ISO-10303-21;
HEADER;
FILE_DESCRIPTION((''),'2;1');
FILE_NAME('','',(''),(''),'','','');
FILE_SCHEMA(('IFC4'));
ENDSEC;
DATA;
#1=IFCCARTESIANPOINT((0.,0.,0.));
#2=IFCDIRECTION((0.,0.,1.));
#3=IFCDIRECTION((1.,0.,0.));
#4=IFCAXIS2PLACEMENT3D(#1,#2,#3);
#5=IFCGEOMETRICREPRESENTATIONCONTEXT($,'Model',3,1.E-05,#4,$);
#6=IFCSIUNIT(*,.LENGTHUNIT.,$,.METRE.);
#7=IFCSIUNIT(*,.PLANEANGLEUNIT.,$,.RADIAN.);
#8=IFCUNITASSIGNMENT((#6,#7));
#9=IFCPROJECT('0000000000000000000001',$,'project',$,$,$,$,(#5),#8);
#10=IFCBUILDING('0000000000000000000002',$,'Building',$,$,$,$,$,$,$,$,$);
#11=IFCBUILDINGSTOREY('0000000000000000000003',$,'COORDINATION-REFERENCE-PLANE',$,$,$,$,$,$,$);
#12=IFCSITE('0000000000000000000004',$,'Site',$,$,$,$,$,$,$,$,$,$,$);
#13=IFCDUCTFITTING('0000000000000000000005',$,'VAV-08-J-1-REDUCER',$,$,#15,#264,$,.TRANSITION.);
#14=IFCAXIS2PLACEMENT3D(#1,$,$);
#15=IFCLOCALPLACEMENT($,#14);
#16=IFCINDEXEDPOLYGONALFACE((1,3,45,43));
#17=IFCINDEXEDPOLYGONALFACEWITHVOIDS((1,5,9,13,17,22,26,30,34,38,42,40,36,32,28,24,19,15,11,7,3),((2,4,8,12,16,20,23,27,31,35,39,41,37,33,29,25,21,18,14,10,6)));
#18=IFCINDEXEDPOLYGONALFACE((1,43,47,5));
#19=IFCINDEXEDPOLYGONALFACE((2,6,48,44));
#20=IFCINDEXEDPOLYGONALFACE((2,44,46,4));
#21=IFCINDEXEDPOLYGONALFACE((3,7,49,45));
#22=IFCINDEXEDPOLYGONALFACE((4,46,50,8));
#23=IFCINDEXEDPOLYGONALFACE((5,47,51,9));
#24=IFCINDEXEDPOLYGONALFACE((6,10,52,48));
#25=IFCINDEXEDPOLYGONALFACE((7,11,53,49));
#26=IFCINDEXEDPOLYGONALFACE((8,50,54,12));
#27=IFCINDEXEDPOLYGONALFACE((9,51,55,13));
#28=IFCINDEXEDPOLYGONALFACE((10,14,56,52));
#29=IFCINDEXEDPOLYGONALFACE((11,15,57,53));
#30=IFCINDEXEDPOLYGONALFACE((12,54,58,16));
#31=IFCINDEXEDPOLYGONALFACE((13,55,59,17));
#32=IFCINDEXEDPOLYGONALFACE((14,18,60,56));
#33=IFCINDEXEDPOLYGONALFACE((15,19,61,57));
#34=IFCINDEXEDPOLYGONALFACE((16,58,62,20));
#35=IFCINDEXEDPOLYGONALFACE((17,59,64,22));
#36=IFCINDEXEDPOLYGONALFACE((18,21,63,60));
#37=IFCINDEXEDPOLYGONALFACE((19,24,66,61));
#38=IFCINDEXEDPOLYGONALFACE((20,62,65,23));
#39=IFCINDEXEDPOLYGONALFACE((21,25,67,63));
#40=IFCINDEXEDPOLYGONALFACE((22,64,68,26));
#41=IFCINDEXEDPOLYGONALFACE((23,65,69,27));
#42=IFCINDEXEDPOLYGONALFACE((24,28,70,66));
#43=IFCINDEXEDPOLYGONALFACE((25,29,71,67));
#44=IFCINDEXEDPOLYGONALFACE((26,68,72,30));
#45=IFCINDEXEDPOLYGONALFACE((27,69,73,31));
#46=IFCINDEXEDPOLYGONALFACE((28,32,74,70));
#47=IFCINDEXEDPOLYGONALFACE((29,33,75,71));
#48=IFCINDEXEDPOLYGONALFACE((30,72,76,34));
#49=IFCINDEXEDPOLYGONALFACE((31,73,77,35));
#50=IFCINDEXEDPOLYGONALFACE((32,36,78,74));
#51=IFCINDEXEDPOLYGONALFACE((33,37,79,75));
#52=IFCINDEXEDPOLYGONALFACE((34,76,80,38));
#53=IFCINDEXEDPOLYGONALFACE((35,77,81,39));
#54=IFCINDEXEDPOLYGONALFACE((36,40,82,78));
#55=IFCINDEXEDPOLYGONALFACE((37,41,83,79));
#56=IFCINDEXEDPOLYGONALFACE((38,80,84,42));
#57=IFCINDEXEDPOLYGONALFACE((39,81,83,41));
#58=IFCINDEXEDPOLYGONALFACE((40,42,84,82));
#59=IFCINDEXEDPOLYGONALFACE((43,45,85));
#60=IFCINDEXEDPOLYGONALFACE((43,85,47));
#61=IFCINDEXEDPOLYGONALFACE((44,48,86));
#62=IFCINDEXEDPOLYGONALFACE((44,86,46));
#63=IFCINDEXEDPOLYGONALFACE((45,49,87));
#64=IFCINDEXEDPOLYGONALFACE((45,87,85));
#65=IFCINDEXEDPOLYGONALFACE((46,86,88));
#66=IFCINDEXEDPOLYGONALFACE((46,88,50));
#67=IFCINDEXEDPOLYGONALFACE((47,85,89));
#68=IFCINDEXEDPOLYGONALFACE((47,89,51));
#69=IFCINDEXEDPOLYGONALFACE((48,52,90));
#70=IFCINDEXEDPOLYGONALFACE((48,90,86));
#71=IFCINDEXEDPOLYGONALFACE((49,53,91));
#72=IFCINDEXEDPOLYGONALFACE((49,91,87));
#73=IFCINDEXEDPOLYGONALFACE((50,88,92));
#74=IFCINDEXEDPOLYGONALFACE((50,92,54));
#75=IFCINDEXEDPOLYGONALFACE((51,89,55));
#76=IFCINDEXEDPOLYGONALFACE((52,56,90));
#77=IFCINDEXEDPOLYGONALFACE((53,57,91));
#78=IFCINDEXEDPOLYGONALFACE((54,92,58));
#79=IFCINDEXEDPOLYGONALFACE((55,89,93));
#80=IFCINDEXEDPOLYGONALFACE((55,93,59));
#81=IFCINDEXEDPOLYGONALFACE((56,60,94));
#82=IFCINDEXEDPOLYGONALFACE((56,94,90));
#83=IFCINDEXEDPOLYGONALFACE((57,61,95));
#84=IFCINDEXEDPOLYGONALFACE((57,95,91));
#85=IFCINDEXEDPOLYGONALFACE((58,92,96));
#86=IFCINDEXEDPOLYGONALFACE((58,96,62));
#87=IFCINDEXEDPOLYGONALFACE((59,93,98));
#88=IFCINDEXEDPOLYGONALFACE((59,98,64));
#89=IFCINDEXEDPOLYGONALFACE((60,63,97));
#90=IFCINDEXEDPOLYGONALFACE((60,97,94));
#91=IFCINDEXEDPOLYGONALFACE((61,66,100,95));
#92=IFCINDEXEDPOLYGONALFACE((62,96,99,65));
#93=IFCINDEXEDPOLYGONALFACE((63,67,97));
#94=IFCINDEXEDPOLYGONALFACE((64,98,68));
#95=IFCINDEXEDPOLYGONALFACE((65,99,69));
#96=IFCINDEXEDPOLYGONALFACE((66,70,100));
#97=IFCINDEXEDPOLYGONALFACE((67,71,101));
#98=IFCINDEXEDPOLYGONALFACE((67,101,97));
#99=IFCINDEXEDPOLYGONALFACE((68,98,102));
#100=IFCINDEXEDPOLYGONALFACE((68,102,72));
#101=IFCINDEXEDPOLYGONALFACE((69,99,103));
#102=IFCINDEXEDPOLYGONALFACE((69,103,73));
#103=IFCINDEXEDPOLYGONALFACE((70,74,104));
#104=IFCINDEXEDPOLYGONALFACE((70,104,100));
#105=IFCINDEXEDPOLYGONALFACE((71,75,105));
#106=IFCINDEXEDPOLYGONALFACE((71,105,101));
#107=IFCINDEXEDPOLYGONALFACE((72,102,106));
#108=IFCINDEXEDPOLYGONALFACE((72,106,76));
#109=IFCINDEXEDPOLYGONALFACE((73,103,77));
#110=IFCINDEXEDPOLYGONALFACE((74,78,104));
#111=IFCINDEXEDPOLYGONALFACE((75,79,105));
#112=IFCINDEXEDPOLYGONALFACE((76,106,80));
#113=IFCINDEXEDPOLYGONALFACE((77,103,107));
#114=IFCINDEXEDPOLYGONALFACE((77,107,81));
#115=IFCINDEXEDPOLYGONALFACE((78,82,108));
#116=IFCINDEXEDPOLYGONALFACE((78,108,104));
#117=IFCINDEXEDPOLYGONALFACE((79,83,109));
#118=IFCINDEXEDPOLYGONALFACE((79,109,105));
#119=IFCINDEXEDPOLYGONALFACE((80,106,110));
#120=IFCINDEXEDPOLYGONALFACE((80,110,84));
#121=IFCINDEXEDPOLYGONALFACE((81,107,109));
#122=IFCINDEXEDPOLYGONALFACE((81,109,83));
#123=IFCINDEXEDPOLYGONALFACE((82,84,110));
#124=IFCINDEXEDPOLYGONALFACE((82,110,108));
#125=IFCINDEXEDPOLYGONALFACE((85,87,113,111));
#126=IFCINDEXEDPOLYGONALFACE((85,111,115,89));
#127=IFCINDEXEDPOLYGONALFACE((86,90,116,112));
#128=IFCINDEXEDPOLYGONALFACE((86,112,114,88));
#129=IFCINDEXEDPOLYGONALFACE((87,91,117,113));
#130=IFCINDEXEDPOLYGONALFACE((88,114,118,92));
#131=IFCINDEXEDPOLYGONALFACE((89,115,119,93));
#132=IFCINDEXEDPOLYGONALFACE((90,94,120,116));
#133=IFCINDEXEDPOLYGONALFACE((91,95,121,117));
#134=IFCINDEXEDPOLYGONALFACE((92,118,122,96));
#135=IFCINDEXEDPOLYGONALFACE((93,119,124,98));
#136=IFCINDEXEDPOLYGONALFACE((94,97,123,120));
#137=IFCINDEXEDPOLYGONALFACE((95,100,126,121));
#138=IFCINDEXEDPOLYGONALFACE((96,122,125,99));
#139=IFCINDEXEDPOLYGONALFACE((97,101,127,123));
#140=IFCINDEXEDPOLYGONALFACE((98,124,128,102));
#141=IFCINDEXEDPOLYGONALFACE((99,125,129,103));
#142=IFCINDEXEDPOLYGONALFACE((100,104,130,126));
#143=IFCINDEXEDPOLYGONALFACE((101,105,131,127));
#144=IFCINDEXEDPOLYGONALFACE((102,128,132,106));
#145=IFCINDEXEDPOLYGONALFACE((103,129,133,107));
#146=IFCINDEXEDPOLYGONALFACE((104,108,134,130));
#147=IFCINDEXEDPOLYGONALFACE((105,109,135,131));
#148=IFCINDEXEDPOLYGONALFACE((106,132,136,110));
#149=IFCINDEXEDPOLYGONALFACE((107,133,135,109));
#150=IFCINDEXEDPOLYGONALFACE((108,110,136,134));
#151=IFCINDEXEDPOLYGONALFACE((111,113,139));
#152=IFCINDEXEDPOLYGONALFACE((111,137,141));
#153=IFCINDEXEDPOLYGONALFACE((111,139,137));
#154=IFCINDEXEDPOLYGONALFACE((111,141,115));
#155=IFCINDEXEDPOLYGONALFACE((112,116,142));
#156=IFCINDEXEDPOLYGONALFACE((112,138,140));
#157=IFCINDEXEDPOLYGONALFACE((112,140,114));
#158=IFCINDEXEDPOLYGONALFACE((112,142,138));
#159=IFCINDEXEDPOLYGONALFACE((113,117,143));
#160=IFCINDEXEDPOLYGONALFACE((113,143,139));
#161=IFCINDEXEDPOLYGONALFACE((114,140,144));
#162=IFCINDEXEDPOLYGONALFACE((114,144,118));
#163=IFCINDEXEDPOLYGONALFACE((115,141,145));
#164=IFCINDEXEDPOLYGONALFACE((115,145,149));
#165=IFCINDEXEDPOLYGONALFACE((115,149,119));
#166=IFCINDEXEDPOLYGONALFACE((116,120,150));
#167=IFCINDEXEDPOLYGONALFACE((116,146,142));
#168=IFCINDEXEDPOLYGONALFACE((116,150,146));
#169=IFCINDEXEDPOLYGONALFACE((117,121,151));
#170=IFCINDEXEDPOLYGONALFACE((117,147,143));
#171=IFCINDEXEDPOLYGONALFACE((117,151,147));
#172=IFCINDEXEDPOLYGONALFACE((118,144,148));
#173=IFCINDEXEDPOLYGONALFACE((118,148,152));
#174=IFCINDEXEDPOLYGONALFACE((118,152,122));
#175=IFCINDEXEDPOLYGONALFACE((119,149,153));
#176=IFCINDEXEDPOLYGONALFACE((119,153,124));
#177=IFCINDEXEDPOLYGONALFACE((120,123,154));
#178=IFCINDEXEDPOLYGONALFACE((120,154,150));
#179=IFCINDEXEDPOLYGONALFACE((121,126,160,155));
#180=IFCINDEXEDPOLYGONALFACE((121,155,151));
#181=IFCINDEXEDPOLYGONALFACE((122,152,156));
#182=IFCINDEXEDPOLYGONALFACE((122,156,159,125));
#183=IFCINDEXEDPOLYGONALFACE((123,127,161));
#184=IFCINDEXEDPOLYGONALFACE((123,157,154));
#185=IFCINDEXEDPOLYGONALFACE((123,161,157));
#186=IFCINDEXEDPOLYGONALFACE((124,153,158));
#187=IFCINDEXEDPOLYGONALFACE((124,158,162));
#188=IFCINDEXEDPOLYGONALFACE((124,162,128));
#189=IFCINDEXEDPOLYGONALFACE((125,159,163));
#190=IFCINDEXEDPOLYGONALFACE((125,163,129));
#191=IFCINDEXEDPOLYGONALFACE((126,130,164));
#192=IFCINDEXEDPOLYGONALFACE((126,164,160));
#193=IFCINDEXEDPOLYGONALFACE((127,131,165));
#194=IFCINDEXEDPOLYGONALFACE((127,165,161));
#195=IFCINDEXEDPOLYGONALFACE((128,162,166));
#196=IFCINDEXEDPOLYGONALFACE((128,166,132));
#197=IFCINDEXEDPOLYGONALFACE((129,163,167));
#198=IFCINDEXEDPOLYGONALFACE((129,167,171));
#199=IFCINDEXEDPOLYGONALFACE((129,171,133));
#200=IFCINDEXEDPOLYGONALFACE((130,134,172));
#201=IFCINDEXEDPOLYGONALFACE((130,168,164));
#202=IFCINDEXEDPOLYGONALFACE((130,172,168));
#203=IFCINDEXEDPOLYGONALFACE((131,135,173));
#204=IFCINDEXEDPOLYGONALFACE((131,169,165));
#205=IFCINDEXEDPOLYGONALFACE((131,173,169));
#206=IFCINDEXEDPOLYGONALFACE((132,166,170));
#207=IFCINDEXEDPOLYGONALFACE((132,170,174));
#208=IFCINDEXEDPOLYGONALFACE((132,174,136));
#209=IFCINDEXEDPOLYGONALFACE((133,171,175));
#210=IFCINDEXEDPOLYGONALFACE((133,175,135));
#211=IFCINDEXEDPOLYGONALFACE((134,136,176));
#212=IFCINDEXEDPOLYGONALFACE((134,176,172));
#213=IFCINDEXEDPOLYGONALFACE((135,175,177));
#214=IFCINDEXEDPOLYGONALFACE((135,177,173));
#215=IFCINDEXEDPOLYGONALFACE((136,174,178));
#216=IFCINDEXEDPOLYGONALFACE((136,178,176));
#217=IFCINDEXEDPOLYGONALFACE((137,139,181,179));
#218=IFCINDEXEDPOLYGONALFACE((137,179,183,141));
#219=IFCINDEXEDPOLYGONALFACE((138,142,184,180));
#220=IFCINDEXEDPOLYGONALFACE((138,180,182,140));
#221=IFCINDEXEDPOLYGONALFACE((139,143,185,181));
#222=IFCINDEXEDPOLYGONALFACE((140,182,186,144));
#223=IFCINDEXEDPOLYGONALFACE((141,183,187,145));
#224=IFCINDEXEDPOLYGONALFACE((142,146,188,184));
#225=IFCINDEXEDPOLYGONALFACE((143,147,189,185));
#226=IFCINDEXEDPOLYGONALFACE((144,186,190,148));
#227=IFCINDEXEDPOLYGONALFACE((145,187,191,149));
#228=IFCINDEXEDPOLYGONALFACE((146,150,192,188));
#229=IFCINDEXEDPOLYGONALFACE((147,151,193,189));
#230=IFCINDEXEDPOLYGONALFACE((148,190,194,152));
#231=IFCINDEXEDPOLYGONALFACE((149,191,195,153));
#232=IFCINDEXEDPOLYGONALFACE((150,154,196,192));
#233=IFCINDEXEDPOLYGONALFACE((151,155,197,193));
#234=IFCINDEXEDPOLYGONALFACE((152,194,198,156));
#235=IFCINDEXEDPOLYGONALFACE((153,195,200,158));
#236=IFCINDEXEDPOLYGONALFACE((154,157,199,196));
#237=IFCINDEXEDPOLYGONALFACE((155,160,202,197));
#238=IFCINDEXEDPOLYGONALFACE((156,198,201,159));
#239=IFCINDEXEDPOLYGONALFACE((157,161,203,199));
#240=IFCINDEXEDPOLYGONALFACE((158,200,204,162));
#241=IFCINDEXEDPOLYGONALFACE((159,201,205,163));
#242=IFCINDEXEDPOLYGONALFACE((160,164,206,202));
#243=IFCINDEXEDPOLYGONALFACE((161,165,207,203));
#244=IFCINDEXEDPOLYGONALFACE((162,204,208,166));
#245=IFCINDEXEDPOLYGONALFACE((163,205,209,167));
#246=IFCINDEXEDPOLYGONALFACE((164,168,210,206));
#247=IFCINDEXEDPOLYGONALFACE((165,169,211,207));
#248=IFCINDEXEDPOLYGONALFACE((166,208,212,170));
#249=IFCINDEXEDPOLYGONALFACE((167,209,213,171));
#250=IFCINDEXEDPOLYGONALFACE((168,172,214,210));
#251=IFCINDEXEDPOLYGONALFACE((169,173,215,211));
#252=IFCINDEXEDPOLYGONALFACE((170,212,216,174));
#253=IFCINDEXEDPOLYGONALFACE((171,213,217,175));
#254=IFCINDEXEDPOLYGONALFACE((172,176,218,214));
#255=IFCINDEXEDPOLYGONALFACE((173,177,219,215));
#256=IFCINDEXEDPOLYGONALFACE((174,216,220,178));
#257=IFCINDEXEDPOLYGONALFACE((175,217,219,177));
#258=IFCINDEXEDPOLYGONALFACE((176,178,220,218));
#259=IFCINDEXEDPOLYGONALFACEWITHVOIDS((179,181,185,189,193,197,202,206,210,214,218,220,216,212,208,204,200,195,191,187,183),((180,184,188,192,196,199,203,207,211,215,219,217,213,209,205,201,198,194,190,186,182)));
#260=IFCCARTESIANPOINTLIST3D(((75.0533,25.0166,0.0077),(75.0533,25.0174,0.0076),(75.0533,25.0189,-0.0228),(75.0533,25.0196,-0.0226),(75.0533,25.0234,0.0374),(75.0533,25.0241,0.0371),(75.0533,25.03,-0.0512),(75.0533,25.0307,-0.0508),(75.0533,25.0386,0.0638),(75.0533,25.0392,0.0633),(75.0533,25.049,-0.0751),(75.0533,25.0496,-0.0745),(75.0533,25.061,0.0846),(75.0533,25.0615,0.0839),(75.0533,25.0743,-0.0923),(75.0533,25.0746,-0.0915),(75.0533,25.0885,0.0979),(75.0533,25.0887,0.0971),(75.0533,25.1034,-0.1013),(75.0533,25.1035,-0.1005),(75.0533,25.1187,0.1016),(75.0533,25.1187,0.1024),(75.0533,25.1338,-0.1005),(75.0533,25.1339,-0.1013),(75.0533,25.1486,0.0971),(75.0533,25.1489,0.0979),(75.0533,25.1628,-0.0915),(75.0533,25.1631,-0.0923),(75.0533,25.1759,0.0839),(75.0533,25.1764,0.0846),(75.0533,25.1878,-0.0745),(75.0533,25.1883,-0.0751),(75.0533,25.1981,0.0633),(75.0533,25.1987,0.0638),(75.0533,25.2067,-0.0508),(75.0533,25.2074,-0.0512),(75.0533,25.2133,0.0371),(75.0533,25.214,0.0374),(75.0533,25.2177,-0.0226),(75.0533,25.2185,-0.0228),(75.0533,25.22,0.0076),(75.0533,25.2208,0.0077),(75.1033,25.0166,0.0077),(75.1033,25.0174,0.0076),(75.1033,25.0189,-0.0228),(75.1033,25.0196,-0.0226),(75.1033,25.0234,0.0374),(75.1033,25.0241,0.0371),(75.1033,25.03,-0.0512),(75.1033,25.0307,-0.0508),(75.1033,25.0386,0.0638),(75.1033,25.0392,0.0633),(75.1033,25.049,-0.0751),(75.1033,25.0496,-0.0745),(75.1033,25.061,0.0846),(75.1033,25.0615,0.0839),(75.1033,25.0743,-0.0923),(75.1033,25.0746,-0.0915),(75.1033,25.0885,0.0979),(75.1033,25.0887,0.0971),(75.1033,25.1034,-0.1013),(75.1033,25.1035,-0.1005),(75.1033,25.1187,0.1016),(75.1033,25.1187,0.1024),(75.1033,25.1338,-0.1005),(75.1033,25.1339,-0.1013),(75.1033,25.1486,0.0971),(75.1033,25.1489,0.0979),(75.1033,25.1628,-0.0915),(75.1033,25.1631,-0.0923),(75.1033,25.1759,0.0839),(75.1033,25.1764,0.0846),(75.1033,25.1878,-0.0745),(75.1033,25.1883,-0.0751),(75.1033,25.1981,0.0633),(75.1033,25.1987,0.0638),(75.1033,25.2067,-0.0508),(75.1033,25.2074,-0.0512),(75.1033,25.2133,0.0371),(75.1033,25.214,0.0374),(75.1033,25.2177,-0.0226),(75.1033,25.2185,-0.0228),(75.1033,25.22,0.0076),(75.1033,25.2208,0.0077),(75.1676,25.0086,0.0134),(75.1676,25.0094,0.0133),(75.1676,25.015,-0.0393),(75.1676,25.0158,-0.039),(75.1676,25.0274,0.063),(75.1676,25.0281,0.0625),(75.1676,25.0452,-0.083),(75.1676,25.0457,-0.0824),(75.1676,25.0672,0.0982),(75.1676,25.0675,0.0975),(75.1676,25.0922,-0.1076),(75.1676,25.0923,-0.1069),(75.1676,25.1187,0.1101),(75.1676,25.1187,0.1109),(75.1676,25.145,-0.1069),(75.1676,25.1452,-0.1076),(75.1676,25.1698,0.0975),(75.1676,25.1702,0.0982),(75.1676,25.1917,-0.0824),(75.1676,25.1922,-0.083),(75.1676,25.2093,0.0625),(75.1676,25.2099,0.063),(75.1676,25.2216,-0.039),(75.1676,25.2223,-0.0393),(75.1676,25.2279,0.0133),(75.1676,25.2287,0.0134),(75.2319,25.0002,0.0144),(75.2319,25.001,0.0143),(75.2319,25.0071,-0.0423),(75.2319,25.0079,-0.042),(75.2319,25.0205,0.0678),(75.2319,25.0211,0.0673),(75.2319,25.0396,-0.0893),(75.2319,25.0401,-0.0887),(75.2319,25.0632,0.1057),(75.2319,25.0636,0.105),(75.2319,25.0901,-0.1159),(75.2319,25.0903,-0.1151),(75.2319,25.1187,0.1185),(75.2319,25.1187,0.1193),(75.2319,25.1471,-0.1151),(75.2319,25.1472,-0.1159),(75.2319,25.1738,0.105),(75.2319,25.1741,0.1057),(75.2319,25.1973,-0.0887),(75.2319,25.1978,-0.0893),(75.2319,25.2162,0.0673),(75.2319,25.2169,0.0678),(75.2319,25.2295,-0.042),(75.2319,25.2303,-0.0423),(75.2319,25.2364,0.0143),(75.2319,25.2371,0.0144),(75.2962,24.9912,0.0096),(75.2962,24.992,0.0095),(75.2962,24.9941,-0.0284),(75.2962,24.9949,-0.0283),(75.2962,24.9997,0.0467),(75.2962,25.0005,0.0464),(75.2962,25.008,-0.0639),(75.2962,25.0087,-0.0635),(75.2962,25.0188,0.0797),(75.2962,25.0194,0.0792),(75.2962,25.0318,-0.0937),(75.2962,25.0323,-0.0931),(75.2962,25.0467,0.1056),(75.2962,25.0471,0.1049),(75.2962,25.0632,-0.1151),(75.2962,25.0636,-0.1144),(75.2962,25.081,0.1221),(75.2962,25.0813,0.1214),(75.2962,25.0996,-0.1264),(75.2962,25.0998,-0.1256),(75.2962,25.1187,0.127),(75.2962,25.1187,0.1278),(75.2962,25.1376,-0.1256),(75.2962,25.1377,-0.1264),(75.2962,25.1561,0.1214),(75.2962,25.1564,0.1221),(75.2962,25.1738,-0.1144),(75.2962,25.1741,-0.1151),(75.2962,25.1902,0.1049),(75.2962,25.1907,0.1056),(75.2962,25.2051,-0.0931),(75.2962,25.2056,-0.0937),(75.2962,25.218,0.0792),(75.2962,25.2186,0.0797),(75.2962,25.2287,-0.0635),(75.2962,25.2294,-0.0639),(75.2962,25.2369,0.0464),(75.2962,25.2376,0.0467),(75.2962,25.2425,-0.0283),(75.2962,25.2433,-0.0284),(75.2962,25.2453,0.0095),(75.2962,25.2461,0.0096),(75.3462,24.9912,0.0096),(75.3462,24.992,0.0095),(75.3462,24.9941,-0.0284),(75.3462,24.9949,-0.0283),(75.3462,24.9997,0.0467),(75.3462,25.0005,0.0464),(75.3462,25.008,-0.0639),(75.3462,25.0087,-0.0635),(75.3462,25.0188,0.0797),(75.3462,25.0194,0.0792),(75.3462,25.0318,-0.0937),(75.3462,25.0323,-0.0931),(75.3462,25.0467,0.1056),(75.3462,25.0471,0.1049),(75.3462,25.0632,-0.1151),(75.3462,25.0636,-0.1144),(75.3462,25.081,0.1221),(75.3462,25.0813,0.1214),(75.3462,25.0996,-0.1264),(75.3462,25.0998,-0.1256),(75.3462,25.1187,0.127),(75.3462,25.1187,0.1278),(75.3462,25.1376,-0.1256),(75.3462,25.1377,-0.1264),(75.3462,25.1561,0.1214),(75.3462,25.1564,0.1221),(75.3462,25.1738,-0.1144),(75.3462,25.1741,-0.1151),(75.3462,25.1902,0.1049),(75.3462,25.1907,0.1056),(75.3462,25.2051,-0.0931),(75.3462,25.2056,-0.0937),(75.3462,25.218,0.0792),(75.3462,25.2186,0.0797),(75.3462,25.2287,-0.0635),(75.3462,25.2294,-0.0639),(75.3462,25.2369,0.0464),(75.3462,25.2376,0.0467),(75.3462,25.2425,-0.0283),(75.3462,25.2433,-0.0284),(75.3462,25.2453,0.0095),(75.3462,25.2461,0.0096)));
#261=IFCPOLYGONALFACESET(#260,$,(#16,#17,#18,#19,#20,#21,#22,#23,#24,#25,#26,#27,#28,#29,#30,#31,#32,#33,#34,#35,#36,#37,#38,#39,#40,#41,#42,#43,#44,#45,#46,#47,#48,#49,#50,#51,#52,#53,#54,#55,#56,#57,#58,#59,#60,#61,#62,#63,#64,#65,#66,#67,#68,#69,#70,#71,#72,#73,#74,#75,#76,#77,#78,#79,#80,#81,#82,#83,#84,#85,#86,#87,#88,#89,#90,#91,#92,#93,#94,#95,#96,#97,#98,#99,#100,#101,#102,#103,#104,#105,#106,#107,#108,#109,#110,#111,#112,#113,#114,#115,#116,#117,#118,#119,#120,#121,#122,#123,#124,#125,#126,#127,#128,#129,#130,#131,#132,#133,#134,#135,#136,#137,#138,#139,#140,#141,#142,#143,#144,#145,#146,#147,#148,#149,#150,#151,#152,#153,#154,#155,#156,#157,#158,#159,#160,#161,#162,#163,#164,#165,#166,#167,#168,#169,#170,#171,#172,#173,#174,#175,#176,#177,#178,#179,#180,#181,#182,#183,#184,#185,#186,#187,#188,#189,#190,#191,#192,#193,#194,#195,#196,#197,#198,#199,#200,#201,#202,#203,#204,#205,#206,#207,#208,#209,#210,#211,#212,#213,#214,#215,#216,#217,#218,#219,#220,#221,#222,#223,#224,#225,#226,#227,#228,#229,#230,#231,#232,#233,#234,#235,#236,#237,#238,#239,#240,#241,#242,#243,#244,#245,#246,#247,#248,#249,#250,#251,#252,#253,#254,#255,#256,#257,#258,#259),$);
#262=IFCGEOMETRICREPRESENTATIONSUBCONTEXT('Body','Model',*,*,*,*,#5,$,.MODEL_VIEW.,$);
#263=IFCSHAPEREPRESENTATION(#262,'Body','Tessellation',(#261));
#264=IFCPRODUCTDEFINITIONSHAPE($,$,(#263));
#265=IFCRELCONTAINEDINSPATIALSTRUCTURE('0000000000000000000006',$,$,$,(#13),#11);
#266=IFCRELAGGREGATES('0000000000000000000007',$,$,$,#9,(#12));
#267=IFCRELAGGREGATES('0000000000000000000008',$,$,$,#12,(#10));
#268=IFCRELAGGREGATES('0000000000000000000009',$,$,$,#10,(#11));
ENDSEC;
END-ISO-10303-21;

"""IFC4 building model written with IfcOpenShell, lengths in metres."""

from ifc_helpers import new_model, entity, si_unit, frame, origin_with_axes, place, context, subcontext, project, spatial, element, save


model = new_model("IFC4")

# Units and contexts
model_context = context("Model", 3, precision=1e-05, world=origin_with_axes())
body_context_1 = subcontext(model_context, "Body", "Model", "MODEL_VIEW")
ifc_project = project(units=[si_unit("LENGTHUNIT", "METRE"), si_unit("PLANEANGLEUNIT", "RADIAN")], contexts=[model_context])

# Site, building, storey
site = spatial("IfcSite", under=ifc_project, Name="Site")
building = spatial("IfcBuilding", under=site, Name="Building")
storey = spatial("IfcBuildingStorey", under=building, Name="COORDINATION-REFERENCE-PLANE")

# Duct fitting
for number, where, z_axis, x_axis, name in (
    (1, (75.3462, 25.1187, 0.0), (0.0, -1.0, 0.0), (0.0, 0.0, 1.0), "VAV-08-J-1-REDUCER"),
):
    element("IfcDuctFitting", number, at=place(None, frame(where, z_axis=z_axis, x_axis=x_axis)), inside=storey, Name=name, PredefinedType="TRANSITION", context=body_context_1, shape_type="SweptSolid", body=[
        entity("IfcRevolvedAreaSolid", entity("IfcArbitraryClosedProfileDef", "AREA", None, entity("IfcPolyline", [entity("IfcCartesianPoint", [0.1278, 0.0]), entity("IfcCartesianPoint", [0.1278, 0.05]), entity("IfcCartesianPoint", [0.1024, 0.2429]), entity("IfcCartesianPoint", [0.1024, 0.2929]), entity("IfcCartesianPoint", [0.1016, 0.2929]), entity("IfcCartesianPoint", [0.1016, 0.2429]), entity("IfcCartesianPoint", [0.127, 0.05]), entity("IfcCartesianPoint", [0.127, 0.0]), entity("IfcCartesianPoint", [0.1278, 0.0])])), entity("IfcAxis2Placement3D", entity("IfcCartesianPoint", [0.0, 0.0, 0.0])), entity("IfcAxis1Placement", entity("IfcCartesianPoint", [0.0, 0.0, 0.0]), entity("IfcDirection", [0.0, 1.0, 0.0])), 6.283185),
    ])

save(model, "model.ifc")
